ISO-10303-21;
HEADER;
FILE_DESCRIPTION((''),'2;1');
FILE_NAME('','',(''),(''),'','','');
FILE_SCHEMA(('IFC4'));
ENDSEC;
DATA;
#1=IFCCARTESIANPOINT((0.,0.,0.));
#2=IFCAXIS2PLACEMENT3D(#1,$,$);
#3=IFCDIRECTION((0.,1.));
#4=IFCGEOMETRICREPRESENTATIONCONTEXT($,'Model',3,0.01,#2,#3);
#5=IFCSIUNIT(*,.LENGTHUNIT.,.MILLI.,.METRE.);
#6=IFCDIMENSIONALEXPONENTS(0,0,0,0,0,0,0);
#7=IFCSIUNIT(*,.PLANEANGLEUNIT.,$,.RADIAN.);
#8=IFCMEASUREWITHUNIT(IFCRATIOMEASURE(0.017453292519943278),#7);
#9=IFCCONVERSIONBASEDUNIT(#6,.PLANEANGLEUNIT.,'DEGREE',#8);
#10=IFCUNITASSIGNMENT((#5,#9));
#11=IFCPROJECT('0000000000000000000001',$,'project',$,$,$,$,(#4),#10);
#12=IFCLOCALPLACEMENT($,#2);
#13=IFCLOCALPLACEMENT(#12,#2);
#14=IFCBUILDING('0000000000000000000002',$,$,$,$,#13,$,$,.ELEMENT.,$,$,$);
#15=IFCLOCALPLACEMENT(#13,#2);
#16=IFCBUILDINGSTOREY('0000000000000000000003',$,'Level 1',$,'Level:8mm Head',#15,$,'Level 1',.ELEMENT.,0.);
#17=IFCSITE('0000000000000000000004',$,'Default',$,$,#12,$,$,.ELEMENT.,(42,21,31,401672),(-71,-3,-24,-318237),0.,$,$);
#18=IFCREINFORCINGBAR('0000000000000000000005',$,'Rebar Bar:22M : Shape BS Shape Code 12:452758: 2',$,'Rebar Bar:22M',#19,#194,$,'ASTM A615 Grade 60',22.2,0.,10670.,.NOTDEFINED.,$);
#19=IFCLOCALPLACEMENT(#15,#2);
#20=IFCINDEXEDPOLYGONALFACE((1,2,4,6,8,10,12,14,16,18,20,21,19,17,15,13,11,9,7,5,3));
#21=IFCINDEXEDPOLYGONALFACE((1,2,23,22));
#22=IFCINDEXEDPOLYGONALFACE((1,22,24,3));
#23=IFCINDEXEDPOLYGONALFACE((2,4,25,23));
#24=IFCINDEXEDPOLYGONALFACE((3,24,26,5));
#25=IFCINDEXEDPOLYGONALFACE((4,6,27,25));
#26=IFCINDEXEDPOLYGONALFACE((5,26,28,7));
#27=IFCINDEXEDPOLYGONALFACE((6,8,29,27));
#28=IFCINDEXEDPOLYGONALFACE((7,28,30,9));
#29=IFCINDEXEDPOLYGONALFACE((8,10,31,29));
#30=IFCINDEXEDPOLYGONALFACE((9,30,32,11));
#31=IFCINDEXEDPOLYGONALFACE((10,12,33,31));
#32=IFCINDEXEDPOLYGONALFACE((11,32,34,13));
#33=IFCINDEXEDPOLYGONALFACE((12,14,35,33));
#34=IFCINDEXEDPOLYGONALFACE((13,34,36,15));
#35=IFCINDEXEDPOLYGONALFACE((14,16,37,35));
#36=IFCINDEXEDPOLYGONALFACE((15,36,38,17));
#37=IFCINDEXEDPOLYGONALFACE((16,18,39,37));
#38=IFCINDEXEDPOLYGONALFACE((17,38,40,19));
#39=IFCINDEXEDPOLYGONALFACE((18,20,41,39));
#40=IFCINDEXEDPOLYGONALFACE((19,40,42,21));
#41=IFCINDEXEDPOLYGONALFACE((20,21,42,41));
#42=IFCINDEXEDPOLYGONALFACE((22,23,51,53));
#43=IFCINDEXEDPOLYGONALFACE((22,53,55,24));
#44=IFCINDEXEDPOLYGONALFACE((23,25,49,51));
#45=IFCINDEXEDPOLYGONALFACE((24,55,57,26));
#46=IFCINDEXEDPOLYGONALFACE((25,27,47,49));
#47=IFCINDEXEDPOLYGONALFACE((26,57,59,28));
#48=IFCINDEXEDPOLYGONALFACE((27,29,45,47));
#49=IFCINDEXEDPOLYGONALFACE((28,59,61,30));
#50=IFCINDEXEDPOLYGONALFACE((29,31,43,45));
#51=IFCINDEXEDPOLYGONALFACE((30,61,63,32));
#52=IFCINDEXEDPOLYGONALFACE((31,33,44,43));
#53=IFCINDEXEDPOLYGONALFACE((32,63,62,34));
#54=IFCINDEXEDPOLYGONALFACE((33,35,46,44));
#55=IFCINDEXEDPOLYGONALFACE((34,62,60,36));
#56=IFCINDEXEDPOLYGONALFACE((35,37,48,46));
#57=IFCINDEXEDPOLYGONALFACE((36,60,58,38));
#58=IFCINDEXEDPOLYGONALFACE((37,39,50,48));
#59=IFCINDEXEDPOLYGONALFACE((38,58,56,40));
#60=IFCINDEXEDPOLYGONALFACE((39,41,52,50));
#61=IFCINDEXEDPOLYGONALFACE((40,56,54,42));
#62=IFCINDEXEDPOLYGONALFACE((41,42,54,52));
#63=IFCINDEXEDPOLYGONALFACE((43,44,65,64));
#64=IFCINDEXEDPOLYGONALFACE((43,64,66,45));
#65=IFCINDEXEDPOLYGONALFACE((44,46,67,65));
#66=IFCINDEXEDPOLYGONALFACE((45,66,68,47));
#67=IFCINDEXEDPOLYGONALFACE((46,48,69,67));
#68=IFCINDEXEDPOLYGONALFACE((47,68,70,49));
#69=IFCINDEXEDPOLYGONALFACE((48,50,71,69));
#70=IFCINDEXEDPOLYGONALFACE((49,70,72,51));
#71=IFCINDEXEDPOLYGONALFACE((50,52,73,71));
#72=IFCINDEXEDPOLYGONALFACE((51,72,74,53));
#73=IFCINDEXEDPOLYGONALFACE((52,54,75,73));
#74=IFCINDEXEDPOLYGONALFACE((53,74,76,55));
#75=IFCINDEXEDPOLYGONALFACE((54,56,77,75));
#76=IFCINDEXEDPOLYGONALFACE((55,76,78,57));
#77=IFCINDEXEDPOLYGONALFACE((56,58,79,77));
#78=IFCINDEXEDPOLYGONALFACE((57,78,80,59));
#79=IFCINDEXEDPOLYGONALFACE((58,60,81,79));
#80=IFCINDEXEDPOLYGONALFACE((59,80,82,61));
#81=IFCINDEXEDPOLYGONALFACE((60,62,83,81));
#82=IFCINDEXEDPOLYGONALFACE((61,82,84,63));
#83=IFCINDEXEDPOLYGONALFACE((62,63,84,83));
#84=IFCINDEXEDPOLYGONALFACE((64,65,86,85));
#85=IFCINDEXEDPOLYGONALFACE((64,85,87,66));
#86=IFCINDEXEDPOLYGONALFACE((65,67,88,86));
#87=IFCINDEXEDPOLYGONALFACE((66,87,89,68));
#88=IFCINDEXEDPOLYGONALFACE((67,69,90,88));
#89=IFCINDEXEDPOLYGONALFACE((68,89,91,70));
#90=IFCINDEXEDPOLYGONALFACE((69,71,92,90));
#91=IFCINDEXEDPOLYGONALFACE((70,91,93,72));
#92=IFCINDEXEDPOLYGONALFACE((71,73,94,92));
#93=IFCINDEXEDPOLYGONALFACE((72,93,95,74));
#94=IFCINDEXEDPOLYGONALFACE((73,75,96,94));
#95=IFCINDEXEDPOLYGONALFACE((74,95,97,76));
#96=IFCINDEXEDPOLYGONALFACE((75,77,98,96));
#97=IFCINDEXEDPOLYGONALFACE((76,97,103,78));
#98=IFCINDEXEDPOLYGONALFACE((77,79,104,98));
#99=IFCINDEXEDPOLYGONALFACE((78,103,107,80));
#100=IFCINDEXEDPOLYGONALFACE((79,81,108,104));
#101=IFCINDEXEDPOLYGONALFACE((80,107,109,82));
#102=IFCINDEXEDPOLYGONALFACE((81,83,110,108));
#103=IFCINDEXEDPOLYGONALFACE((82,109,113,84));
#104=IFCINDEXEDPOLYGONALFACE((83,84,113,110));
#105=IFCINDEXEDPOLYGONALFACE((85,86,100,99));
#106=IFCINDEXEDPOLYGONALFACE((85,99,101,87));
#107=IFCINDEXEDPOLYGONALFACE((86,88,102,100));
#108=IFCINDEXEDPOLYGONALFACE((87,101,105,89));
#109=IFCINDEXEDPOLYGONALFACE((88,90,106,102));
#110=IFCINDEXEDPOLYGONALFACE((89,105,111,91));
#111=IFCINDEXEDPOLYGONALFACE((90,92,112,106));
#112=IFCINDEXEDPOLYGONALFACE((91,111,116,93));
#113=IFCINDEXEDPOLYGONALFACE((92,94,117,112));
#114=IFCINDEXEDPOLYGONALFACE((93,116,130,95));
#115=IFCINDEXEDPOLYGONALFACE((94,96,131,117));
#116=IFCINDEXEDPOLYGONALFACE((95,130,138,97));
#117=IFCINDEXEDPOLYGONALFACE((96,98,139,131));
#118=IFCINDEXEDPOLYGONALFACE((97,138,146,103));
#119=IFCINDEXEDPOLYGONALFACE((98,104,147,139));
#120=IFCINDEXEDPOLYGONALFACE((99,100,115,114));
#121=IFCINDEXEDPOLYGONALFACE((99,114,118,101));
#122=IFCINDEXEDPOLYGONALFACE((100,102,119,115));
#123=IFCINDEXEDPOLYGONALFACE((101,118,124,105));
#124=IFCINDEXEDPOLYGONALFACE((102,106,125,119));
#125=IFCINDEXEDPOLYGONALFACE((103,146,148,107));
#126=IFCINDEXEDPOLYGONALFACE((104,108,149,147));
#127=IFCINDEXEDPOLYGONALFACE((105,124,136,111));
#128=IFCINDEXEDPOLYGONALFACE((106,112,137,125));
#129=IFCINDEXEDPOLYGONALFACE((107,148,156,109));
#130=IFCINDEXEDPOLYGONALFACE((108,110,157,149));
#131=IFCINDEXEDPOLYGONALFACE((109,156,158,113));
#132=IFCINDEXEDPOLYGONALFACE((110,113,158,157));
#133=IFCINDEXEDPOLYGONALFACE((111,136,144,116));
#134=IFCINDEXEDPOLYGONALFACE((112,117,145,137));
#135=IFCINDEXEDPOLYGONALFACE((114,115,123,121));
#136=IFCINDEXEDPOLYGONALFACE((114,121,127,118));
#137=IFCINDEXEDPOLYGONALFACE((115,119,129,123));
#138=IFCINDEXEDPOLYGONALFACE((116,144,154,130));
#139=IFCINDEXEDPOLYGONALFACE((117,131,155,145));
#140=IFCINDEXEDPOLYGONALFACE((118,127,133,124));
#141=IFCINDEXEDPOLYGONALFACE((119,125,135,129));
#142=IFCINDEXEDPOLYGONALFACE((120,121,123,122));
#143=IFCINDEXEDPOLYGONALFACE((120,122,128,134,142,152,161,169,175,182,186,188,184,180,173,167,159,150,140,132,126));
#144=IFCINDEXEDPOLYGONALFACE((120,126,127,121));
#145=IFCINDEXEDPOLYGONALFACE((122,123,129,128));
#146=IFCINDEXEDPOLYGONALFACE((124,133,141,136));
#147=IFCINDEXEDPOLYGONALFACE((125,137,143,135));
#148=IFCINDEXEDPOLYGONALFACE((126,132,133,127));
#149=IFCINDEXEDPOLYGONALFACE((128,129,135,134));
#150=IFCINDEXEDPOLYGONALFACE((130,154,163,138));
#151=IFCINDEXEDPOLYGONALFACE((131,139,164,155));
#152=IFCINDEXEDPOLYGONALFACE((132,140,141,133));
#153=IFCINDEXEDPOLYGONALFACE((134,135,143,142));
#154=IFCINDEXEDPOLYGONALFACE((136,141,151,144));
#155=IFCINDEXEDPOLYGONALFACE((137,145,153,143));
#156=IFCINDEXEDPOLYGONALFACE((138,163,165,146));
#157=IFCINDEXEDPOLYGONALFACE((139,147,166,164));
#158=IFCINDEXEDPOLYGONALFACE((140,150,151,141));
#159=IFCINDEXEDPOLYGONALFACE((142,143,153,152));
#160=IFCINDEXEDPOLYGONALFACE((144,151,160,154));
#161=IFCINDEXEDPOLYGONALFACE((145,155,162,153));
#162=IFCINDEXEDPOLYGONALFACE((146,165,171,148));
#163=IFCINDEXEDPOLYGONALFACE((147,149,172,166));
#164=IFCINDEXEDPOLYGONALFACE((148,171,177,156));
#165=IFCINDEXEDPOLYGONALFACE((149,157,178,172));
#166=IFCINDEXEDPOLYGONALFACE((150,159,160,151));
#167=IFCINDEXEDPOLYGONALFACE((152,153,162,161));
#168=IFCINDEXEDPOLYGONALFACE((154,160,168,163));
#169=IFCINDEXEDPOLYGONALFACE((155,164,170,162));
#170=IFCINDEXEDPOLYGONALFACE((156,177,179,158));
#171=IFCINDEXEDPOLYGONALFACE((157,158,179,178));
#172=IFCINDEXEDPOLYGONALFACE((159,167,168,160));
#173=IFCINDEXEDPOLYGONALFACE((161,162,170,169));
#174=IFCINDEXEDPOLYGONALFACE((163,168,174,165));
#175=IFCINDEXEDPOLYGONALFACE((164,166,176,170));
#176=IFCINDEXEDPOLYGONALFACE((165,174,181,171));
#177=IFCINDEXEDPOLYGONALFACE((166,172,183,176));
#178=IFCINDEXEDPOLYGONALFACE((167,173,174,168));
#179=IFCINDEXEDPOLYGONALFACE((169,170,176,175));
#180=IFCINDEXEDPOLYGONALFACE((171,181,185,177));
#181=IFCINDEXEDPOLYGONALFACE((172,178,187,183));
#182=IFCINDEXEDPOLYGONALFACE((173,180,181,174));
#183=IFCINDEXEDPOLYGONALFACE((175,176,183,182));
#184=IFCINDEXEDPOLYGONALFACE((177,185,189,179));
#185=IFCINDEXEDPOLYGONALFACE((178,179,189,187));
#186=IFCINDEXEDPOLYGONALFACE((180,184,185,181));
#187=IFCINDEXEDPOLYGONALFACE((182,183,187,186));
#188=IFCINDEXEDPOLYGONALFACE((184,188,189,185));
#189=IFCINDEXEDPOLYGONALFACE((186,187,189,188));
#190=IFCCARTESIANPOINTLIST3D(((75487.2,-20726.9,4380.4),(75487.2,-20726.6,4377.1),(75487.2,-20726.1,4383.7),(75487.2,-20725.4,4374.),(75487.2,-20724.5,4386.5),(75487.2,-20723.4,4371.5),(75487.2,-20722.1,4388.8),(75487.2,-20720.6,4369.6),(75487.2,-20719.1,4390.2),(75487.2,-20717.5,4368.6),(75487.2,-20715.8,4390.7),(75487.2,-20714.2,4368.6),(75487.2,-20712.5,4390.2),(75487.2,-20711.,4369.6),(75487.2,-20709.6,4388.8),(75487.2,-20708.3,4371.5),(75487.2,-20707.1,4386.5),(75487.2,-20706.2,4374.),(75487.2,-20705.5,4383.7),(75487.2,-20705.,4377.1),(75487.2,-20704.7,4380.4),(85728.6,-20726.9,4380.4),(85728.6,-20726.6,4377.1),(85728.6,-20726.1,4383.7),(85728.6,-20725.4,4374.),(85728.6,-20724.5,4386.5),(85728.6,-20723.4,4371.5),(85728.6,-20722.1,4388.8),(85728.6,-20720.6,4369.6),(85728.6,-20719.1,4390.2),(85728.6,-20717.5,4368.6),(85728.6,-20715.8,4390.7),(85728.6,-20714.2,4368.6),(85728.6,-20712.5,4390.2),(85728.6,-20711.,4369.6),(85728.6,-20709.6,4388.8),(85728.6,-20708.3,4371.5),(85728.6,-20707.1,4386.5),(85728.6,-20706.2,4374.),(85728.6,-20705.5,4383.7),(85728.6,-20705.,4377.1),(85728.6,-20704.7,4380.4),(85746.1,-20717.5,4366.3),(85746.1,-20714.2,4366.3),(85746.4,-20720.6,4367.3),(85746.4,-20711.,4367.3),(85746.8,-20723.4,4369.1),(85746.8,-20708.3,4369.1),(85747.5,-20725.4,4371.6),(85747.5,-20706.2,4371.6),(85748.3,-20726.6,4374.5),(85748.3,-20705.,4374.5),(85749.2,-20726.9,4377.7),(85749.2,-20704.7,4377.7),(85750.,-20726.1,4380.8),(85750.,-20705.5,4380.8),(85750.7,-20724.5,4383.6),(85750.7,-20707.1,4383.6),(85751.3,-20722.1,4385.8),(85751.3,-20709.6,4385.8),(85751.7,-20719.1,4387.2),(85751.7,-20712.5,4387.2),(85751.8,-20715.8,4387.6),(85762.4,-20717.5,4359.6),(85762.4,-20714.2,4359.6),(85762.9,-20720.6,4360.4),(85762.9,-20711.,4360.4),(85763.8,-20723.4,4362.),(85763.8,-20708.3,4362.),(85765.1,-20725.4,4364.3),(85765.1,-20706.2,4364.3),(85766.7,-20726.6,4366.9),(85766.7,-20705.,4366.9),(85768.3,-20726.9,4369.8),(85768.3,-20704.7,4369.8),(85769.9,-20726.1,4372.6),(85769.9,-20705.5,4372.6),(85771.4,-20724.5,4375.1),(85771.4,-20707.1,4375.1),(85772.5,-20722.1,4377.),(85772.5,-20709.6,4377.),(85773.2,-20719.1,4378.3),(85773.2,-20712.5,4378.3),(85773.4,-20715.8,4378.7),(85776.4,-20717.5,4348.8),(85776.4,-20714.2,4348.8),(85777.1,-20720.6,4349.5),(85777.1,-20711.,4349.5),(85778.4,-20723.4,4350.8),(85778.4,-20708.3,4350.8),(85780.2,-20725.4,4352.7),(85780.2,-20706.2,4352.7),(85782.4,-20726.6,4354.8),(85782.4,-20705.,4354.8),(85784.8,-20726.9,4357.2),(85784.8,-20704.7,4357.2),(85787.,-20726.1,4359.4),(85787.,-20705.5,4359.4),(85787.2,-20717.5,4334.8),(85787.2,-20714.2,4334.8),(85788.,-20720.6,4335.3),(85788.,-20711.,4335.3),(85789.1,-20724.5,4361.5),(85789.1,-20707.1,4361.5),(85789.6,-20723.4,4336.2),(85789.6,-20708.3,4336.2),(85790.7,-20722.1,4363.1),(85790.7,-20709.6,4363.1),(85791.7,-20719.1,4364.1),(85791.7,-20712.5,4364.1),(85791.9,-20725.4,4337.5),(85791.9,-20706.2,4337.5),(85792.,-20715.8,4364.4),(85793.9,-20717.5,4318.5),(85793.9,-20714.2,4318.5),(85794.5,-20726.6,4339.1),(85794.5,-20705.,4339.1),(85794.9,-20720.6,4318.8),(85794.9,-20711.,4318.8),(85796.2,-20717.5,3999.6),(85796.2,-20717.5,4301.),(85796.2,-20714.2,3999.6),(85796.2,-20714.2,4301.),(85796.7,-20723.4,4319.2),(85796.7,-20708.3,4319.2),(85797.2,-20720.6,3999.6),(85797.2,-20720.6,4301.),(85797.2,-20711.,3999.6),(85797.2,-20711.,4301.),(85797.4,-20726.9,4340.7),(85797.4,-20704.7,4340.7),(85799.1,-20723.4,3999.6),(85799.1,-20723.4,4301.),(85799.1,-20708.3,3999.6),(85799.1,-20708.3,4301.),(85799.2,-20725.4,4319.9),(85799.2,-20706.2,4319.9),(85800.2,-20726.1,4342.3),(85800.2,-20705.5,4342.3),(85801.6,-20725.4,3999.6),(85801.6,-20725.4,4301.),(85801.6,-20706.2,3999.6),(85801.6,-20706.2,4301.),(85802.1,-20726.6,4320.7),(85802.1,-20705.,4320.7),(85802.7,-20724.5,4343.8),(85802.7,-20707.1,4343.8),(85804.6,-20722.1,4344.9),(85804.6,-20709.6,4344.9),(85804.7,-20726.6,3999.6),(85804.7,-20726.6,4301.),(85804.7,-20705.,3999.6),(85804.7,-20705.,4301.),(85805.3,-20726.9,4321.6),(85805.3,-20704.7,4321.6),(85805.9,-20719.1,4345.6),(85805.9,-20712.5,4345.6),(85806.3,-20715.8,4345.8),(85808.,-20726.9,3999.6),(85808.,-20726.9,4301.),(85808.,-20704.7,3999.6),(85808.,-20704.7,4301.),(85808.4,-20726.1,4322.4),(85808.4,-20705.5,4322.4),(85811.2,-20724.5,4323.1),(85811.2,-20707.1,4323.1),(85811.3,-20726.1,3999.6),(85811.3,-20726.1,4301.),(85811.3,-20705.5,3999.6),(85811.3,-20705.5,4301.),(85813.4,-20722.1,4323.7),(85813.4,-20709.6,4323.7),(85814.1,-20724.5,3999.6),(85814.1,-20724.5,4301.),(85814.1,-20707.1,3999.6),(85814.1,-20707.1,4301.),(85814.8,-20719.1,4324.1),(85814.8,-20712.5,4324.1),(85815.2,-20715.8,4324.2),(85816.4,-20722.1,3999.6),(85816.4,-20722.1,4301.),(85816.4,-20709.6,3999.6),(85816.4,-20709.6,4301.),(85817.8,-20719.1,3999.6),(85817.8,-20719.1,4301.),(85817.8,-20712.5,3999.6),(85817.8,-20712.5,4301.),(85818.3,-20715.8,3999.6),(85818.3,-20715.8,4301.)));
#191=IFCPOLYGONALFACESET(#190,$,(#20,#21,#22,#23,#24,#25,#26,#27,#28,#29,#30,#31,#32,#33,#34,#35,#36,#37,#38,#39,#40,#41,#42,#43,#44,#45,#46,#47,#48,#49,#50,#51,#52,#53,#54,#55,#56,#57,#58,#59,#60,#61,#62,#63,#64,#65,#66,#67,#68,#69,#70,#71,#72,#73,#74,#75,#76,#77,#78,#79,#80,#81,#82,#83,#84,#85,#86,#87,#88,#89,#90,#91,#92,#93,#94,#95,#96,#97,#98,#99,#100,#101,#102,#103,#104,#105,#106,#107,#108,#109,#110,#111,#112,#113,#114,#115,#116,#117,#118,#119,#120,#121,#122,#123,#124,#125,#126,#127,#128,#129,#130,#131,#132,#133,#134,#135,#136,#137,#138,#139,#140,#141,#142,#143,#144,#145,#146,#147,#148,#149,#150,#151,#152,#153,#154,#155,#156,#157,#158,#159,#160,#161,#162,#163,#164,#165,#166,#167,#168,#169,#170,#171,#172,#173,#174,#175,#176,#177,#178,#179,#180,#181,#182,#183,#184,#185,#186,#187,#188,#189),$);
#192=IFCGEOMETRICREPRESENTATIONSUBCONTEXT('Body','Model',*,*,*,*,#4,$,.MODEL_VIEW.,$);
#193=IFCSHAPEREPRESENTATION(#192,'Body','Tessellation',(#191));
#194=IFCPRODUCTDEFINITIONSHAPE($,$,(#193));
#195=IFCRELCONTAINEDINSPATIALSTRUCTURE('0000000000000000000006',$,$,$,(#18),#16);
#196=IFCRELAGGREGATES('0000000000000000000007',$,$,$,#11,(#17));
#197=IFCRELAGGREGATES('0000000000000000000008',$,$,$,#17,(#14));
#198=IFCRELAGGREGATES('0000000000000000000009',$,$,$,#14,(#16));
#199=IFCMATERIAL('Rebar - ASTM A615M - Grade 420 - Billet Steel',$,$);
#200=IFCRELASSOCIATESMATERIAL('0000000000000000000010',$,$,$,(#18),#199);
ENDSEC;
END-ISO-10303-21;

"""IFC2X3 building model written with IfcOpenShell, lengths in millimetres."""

from ifc_helpers import new_model, entity, si_unit, converted_unit, direction, origin, place, context, subcontext, project, spatial, material, element, save


model = new_model("IFC2X3")

# Units and contexts
model_context = context("Model", 3, precision=0.01, world=origin(), true_north=direction((0.0, 1.0)))
body_context = subcontext(model_context, "Body", "Model", "MODEL_VIEW")
ifc_project = project(units=[si_unit("LENGTHUNIT", "METRE", prefix="MILLI"), converted_unit("PLANEANGLEUNIT", "DEGREE", entity("IfcRatioMeasure", 0.017453292519943278), si_unit("PLANEANGLEUNIT", "RADIAN"), dimensions=[0, 0, 0, 0, 0, 0, 0])], contexts=[model_context])

# Site, building, storey
site_placement = place(None, origin())
site = spatial("IfcSite", under=ifc_project, at=site_placement, Name="Default", CompositionType="ELEMENT", RefLatitude=(42, 21, 31, 401672), RefLongitude=(-71, -3, -24, -318237), RefElevation=0.0)
building_placement = place(site_placement, origin())
building = spatial("IfcBuilding", under=site, at=building_placement, CompositionType="ELEMENT")
storey_placement = place(building_placement, origin())
storey = spatial("IfcBuildingStorey", under=building, at=storey_placement, Name="Level 1", ObjectType="Level:8mm Head", LongName="Level 1", CompositionType="ELEMENT", Elevation=0.0)

# Reinforcing bar
ifc_material = material(Name="Rebar - ASTM A615M - Grade 420 - Billet Steel")
reinforcing_bar_1_placement = place(storey_placement, origin())
element("IfcReinforcingBar", 1, at=reinforcing_bar_1_placement, inside=storey, material=ifc_material, Name="Rebar Bar:22M : Shape BS Shape Code 12:452758: 2", SteelGrade="ASTM A615 Grade 60", ObjectType="Rebar Bar:22M", BarLength=10670.0, BarRole="NOTDEFINED", CrossSectionArea=0.0, NominalDiameter=22.2, context=body_context, shape_type="AdvancedSweptSolid", body=[
    entity("IfcSweptDiskSolid", entity("IfcCompositeCurve", [entity("IfcCompositeCurveSegment", "CONTINUOUS", True, entity("IfcPolyline", [entity("IfcCartesianPoint", [75487.2, -20715.8, 4379.6]), entity("IfcCartesianPoint", [85728.6, -20715.8, 4379.6])])), entity("IfcCompositeCurveSegment", "CONTINUOUS", True, entity("IfcTrimmedCurve", entity("IfcCircle", entity("IfcAxis2Placement3D", entity("IfcCartesianPoint", [85728.6, -20715.8, 4301.0]), entity("IfcDirection", [0.0, 1.0, 0.0]), entity("IfcDirection", [1.0, 0.0, 0.0])), 78.6), [entity("IfcParameterValue", 270.0)], [entity("IfcParameterValue", 360.0)], True, "PARAMETER")), entity("IfcCompositeCurveSegment", "CONTINUOUS", True, entity("IfcPolyline", [entity("IfcCartesianPoint", [85807.2, -20715.8, 4301.0]), entity("IfcCartesianPoint", [85807.2, -20715.8, 3999.6])]))], False), 11.1, None, 0.0, 92.0),
])

save(model, "model.ifc")
